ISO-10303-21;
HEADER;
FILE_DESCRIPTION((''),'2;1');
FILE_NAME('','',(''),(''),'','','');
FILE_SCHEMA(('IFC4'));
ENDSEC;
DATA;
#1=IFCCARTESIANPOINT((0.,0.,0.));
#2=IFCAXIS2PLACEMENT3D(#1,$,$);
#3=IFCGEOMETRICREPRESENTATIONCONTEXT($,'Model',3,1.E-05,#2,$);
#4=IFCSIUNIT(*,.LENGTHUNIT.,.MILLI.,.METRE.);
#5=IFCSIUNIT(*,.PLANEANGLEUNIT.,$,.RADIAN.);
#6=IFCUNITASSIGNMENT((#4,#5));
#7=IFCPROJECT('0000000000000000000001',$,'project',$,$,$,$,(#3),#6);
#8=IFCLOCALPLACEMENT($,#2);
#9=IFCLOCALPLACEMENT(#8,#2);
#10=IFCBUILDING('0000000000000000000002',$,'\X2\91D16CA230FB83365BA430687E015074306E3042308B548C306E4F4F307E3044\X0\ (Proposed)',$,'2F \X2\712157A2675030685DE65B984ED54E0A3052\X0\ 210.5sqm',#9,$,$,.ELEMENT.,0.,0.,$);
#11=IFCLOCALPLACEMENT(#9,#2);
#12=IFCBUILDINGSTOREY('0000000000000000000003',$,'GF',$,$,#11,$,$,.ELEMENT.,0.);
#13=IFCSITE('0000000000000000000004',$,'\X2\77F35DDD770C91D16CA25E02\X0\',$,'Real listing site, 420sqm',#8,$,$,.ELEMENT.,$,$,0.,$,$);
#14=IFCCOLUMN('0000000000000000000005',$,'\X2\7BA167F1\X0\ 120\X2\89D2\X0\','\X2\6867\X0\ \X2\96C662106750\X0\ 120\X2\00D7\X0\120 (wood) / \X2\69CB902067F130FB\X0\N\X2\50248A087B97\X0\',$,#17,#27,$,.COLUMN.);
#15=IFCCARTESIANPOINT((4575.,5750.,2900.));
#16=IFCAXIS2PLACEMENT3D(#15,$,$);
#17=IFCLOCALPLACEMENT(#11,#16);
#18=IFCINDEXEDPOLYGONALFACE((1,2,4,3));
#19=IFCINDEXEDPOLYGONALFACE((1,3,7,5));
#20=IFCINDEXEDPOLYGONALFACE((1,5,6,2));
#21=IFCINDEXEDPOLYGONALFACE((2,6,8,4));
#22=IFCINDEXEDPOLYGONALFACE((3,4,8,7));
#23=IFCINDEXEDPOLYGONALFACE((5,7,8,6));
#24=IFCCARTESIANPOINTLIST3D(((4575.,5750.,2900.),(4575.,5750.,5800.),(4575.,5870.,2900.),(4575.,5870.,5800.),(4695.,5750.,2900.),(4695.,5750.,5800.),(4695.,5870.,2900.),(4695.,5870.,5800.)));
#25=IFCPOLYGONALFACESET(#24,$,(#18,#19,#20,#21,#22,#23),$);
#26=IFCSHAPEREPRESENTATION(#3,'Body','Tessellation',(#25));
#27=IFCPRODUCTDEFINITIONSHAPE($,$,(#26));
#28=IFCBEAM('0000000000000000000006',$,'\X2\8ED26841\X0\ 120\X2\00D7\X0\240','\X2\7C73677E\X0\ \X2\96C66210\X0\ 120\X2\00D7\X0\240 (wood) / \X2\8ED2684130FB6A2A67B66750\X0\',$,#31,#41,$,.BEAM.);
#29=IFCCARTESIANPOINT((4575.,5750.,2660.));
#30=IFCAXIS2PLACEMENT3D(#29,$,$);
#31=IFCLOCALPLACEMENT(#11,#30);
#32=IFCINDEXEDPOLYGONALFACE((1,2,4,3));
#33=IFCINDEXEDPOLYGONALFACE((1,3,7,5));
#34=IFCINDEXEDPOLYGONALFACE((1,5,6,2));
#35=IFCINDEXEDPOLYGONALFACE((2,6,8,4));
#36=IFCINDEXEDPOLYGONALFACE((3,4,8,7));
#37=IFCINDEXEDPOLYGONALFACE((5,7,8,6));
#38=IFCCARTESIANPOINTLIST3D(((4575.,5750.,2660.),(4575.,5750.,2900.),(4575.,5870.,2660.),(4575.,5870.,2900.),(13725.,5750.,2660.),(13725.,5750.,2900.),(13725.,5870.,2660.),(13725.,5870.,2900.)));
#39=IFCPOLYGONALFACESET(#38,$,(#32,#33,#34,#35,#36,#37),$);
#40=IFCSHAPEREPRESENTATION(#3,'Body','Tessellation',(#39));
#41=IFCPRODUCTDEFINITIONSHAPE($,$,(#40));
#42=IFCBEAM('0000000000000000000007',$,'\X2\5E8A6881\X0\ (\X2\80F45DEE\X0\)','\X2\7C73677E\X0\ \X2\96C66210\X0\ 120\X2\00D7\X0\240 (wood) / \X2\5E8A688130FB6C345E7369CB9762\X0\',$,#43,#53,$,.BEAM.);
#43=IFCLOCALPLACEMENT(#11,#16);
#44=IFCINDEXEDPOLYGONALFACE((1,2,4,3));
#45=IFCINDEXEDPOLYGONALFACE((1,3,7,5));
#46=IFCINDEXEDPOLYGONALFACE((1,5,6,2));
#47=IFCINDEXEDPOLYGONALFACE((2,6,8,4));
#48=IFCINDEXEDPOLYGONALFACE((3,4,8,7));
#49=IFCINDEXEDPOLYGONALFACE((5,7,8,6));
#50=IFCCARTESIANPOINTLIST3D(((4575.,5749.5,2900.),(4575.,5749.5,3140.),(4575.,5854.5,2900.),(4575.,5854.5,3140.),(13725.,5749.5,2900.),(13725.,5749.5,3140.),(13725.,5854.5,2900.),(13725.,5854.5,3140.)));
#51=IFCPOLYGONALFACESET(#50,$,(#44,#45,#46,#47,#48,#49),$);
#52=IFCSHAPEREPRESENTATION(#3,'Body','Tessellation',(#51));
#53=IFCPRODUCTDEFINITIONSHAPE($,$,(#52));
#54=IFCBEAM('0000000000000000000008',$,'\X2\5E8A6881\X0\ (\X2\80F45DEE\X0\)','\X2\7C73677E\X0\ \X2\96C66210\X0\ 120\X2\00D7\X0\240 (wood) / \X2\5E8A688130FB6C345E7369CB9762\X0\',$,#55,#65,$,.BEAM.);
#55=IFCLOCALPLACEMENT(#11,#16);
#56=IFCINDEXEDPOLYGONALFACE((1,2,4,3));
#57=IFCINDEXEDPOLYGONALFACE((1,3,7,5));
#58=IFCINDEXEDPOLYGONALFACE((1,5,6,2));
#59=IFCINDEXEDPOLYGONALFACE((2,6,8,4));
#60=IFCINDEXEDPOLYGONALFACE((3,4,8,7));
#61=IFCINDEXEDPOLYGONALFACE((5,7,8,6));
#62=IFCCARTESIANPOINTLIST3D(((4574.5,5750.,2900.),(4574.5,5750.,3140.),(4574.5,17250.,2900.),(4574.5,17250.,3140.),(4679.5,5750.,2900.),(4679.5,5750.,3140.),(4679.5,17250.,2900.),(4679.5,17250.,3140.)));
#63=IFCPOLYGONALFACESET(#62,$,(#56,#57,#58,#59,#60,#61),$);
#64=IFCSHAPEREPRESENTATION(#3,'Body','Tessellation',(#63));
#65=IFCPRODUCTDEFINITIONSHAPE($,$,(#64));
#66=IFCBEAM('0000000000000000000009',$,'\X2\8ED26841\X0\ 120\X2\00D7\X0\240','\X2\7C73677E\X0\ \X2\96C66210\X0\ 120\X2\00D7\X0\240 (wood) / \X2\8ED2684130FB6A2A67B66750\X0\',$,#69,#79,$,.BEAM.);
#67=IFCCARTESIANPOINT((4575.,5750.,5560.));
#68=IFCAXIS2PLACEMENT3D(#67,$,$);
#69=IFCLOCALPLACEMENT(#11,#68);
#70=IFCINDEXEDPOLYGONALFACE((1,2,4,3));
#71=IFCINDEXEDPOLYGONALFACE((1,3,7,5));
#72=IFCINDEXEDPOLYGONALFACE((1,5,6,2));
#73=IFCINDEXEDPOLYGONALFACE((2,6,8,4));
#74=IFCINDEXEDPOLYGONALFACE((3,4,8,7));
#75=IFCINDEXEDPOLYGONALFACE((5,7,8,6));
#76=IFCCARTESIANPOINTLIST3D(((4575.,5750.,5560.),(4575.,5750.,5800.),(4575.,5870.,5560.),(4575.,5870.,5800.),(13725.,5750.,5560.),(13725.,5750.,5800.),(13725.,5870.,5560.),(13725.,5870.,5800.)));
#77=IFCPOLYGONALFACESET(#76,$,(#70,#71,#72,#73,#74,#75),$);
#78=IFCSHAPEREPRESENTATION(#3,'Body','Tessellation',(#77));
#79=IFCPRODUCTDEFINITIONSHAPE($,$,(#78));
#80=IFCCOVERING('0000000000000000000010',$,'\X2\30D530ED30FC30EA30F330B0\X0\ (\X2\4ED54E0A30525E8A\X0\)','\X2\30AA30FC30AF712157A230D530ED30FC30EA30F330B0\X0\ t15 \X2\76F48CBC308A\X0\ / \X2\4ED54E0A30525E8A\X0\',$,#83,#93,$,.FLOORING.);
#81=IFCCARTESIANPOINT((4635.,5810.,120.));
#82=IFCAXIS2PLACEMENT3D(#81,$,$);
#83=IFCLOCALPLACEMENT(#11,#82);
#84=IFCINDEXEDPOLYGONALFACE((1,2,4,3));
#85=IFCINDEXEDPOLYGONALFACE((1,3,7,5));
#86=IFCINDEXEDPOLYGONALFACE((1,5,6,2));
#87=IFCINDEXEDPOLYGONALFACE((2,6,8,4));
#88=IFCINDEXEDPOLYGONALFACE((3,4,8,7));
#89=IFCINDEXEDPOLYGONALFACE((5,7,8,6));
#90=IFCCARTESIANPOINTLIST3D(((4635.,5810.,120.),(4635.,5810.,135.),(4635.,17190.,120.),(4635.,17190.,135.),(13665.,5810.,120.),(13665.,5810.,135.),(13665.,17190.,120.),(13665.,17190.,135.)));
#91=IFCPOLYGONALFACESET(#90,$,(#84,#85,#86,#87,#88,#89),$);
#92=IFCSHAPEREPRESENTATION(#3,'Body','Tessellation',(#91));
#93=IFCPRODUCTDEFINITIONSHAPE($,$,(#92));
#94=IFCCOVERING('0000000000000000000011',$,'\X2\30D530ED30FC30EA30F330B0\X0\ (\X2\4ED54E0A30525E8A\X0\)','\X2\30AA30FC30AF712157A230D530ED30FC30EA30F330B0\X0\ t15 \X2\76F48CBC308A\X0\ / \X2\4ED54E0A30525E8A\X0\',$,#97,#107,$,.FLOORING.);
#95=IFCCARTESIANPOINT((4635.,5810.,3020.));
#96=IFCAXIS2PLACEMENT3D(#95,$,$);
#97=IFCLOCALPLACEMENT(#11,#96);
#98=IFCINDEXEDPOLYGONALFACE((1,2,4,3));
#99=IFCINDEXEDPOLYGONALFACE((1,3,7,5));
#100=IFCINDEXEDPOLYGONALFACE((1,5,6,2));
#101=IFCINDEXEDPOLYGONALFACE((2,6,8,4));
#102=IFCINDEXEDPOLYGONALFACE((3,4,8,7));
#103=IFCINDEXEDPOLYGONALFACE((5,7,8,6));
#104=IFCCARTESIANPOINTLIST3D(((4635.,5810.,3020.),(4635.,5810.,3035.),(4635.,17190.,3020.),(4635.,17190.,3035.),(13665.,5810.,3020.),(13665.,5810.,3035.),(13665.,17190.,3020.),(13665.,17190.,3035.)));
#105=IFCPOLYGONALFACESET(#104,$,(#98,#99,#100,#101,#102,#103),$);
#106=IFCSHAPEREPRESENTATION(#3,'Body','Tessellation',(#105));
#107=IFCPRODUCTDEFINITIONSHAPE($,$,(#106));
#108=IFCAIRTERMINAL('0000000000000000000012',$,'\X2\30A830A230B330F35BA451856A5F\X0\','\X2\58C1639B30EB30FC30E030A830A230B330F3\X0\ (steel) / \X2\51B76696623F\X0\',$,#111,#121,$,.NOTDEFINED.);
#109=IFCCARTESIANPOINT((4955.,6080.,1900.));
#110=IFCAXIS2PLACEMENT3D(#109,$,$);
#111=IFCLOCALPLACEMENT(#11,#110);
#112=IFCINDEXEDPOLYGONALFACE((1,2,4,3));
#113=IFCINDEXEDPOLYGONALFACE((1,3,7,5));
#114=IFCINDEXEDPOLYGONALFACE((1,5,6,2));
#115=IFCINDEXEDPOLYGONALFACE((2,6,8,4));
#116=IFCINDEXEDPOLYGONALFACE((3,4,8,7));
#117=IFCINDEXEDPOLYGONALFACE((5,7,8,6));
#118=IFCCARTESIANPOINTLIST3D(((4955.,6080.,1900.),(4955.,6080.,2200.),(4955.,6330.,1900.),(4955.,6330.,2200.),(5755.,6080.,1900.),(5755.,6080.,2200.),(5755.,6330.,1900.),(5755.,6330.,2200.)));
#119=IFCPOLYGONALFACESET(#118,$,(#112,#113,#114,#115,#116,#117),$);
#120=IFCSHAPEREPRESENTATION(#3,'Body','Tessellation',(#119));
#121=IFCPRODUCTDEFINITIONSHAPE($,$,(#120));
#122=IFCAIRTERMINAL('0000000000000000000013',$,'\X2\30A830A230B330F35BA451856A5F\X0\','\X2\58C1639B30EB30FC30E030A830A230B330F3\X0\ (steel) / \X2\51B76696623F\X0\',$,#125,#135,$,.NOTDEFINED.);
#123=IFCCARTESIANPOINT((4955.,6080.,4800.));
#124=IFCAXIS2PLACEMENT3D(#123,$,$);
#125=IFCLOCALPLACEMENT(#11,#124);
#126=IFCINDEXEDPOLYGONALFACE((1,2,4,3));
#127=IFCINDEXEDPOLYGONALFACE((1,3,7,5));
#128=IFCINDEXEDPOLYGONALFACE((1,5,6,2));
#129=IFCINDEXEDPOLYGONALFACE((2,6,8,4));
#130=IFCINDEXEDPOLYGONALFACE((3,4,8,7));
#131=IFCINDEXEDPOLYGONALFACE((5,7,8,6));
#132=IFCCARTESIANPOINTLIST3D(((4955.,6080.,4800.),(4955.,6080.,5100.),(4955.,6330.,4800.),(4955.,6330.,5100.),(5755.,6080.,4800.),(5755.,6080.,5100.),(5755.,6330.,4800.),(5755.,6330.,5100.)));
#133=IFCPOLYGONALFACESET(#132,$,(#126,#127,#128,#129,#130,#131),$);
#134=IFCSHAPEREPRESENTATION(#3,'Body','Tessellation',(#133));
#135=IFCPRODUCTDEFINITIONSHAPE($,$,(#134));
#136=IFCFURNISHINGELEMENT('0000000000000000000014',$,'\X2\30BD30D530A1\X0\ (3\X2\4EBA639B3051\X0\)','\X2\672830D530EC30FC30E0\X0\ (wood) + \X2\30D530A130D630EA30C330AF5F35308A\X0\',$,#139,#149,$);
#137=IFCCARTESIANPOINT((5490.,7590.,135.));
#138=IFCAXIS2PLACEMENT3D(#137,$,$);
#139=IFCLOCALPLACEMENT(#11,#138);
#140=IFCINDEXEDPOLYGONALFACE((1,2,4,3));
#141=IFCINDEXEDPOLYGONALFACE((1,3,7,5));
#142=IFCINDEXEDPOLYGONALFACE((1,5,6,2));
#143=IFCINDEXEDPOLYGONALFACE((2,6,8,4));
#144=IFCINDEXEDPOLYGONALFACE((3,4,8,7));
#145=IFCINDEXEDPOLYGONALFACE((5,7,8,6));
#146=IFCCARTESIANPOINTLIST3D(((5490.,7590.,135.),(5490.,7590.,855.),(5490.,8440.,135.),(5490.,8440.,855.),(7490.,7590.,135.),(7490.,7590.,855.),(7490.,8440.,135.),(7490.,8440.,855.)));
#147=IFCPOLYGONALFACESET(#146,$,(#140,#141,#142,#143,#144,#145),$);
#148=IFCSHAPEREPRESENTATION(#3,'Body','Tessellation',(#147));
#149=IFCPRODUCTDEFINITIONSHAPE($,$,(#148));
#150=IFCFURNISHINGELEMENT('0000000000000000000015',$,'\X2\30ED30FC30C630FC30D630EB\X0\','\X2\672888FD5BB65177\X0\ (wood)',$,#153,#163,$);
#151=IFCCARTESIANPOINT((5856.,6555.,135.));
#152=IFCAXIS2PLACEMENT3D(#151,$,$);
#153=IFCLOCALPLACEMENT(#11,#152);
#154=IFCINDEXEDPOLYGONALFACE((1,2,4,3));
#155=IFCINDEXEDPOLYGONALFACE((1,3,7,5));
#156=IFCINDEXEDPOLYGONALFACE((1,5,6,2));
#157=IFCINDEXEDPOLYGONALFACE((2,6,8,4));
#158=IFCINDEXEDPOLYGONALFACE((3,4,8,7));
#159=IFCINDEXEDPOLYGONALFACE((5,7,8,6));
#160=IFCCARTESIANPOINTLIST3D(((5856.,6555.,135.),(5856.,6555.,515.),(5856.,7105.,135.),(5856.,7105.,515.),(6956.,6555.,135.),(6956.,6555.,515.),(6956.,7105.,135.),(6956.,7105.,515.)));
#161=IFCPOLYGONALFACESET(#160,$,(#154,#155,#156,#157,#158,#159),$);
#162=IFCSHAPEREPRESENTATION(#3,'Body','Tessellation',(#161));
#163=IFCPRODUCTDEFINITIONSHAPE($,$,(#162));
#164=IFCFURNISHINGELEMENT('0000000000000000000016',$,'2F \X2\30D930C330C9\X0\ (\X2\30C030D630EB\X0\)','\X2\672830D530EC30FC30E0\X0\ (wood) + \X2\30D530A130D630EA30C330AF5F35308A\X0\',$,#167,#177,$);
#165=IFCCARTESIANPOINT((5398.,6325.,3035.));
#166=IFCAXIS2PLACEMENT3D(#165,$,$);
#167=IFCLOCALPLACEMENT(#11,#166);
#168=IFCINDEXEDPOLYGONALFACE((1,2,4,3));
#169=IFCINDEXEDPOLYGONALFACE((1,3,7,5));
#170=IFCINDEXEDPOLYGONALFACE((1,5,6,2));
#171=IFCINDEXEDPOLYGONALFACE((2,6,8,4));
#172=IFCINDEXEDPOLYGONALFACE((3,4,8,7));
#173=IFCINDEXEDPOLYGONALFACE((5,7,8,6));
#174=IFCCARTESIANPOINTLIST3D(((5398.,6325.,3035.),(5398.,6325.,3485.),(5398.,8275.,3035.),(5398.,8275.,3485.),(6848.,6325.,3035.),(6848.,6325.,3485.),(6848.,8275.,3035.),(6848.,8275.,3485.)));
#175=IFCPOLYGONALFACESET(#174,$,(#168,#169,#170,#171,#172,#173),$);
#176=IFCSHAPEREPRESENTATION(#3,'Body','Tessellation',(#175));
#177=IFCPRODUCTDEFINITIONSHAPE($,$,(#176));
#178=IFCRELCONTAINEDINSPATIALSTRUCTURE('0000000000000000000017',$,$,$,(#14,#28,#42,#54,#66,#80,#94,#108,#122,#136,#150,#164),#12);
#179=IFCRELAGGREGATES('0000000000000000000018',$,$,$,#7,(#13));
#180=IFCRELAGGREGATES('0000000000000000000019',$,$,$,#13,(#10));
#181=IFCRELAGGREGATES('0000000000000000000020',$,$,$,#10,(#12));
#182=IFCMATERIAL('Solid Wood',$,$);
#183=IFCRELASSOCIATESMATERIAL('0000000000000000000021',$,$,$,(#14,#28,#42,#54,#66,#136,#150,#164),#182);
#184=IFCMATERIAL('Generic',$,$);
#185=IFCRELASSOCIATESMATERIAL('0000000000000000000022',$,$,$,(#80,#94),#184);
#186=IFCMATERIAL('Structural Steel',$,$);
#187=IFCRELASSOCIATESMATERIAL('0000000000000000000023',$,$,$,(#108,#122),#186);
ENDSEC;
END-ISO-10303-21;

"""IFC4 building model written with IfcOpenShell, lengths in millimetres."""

from ifc_helpers import new_model, si_unit, frame, frame_2d, origin, place, context, project, spatial, rectangle, extrude, material, element, save


model = new_model("IFC4")

# Units and contexts
model_context = context("Model", 3, precision=1e-05, world=origin())
ifc_project = project(units=[si_unit("LENGTHUNIT", "METRE", prefix="MILLI"), si_unit("PLANEANGLEUNIT", "RADIAN")], contexts=[model_context])

# Site, building, storey
site_placement = place(None, origin())
site = spatial("IfcSite", under=ifc_project, at=site_placement, Name="石川県金沢市", ObjectType="Real listing site, 420sqm", CompositionType="ELEMENT", RefElevation=0.0)
building_placement = place(site_placement, origin())
building = spatial("IfcBuilding", under=site, at=building_placement, Name="金沢・茶室と縁側のある和の住まい (Proposed)", ObjectType="2F 無垢材と左官仕上げ 210.5sqm", CompositionType="ELEMENT", ElevationOfRefHeight=0.0, ElevationOfTerrain=0.0)
storey_placement = place(building_placement, origin())
storey = spatial("IfcBuildingStorey", under=building, at=storey_placement, Name="GF", CompositionType="ELEMENT", Elevation=0.0)

# Column
ifc_material_1 = material(Name="Solid Wood")
column_1_placement = place(storey_placement, frame((4575.0, 5750.0, 2900.0)))
element("IfcColumn", 1, at=column_1_placement, inside=storey, material=ifc_material_1, Name="管柱 120角", Description="桧 集成材 120×120 (wood) / 構造柱・N値計算", PredefinedType="COLUMN", context=model_context, shape_type="SweptSolid", body=[
    extrude(rectangle(XDim=120.0, YDim=120.0, at=frame_2d((60.0, 60.0))), frame((4575.0, 5750.0, 2900.0)), (0.0, 0.0, 1.0), 2900.0),
])

# Beams
beam_1_placement = place(storey_placement, frame((4575.0, 5750.0, 2660.0)))
element("IfcBeam", 2, at=beam_1_placement, inside=storey, material=ifc_material_1, Name="軒桁 120×240", Description="米松 集成 120×240 (wood) / 軒桁・横架材", PredefinedType="BEAM", context=model_context, shape_type="SweptSolid", body=[
    extrude(rectangle(XDim=9150.0, YDim=120.0, at=frame_2d((4575.0, 60.0))), frame((4575.0, 5750.0, 2660.0)), (0.0, 0.0, 1.0), 240.0),
])
beam_2_placement = place(storey_placement, frame((4575.0, 5750.0, 2900.0)))
element("IfcBeam", 3, at=beam_2_placement, inside=storey, material=ifc_material_1, Name="床梁 (胴差)", Description="米松 集成 120×240 (wood) / 床梁・水平構面", PredefinedType="BEAM", context=model_context, shape_type="SweptSolid", body=[
    extrude(rectangle(XDim=9150.0, YDim=105.0, at=frame_2d((4575.0, 52.0))), frame((4575.0, 5750.0, 2900.0)), (0.0, 0.0, 1.0), 240.0),
])
beam_3_placement = place(storey_placement, frame((4575.0, 5750.0, 2900.0)))
element("IfcBeam", 4, at=beam_3_placement, inside=storey, material=ifc_material_1, Name="床梁 (胴差)", Description="米松 集成 120×240 (wood) / 床梁・水平構面", PredefinedType="BEAM", context=model_context, shape_type="SweptSolid", body=[
    extrude(rectangle(XDim=105.0, YDim=11500.0, at=frame_2d((52.0, 5750.0))), frame((4575.0, 5750.0, 2900.0)), (0.0, 0.0, 1.0), 240.0),
])
beam_4_placement = place(storey_placement, frame((4575.0, 5750.0, 5560.0)))
element("IfcBeam", 5, at=beam_4_placement, inside=storey, material=ifc_material_1, Name="軒桁 120×240", Description="米松 集成 120×240 (wood) / 軒桁・横架材", PredefinedType="BEAM", context=model_context, shape_type="SweptSolid", body=[
    extrude(rectangle(XDim=9150.0, YDim=120.0, at=frame_2d((4575.0, 60.0))), frame((4575.0, 5750.0, 5560.0)), (0.0, 0.0, 1.0), 240.0),
])

# Coverings
ifc_material_2 = material(Name="Generic")
covering_1_placement = place(storey_placement, frame((4635.0, 5810.0, 120.0)))
element("IfcCovering", 6, at=covering_1_placement, inside=storey, material=ifc_material_2, Name="フローリング (仕上げ床)", Description="オーク無垢フローリング t15 直貼り / 仕上げ床", PredefinedType="FLOORING", context=model_context, shape_type="SweptSolid", body=[
    extrude(rectangle(XDim=9030.0, YDim=11380.0, at=frame_2d((4515.0, 5690.0))), frame((4635.0, 5810.0, 120.0)), (0.0, 0.0, 1.0), 15.0),
])
covering_2_placement = place(storey_placement, frame((4635.0, 5810.0, 3020.0)))
element("IfcCovering", 7, at=covering_2_placement, inside=storey, material=ifc_material_2, Name="フローリング (仕上げ床)", Description="オーク無垢フローリング t15 直貼り / 仕上げ床", PredefinedType="FLOORING", context=model_context, shape_type="SweptSolid", body=[
    extrude(rectangle(XDim=9030.0, YDim=11380.0, at=frame_2d((4515.0, 5690.0))), frame((4635.0, 5810.0, 3020.0)), (0.0, 0.0, 1.0), 15.0),
])

# Air terminals
ifc_material_3 = material(Name="Structural Steel")
air_terminal_1_placement = place(storey_placement, frame((4955.0, 6080.0, 1900.0)))
element("IfcAirTerminal", 8, at=air_terminal_1_placement, inside=storey, material=ifc_material_3, Name="エアコン室内機", Description="壁掛ルームエアコン (steel) / 冷暖房", PredefinedType="NOTDEFINED", context=model_context, shape_type="SweptSolid", body=[
    extrude(rectangle(XDim=800.0, YDim=250.0, at=frame_2d((400.0, 125.0))), frame((4955.0, 6080.0, 1900.0)), (0.0, 0.0, 1.0), 300.0),
])
air_terminal_2_placement = place(storey_placement, frame((4955.0, 6080.0, 4800.0)))
element("IfcAirTerminal", 9, at=air_terminal_2_placement, inside=storey, material=ifc_material_3, Name="エアコン室内機", Description="壁掛ルームエアコン (steel) / 冷暖房", PredefinedType="NOTDEFINED", context=model_context, shape_type="SweptSolid", body=[
    extrude(rectangle(XDim=800.0, YDim=250.0, at=frame_2d((400.0, 125.0))), frame((4955.0, 6080.0, 4800.0)), (0.0, 0.0, 1.0), 300.0),
])

# Furnishing elements
furnishing_1_placement = place(storey_placement, frame((5490.0, 7590.0, 135.0)))
element("IfcFurnishingElement", 10, at=furnishing_1_placement, inside=storey, material=ifc_material_1, Name="ソファ (3人掛け)", Description="木フレーム (wood) + ファブリック張り", context=model_context, shape_type="SweptSolid", body=[
    extrude(rectangle(XDim=2000.0, YDim=850.0, at=frame_2d((1000.0, 425.0))), frame((5490.0, 7590.0, 135.0)), (0.0, 0.0, 1.0), 720.0),
])
furnishing_2_placement = place(storey_placement, frame((5856.0, 6555.0, 135.0)))
element("IfcFurnishingElement", 11, at=furnishing_2_placement, inside=storey, material=ifc_material_1, Name="ローテーブル", Description="木製家具 (wood)", context=model_context, shape_type="SweptSolid", body=[
    extrude(rectangle(XDim=1100.0, YDim=550.0, at=frame_2d((550.0, 275.0))), frame((5856.0, 6555.0, 135.0)), (0.0, 0.0, 1.0), 380.0),
])
furnishing_3_placement = place(storey_placement, frame((5398.0, 6325.0, 3035.0)))
element("IfcFurnishingElement", 12, at=furnishing_3_placement, inside=storey, material=ifc_material_1, Name="2F ベッド (ダブル)", Description="木フレーム (wood) + ファブリック張り", context=model_context, shape_type="SweptSolid", body=[
    extrude(rectangle(XDim=1450.0, YDim=1950.0, at=frame_2d((725.0, 975.0))), frame((5398.0, 6325.0, 3035.0)), (0.0, 0.0, 1.0), 450.0),
])

save(model, "model.ifc")
